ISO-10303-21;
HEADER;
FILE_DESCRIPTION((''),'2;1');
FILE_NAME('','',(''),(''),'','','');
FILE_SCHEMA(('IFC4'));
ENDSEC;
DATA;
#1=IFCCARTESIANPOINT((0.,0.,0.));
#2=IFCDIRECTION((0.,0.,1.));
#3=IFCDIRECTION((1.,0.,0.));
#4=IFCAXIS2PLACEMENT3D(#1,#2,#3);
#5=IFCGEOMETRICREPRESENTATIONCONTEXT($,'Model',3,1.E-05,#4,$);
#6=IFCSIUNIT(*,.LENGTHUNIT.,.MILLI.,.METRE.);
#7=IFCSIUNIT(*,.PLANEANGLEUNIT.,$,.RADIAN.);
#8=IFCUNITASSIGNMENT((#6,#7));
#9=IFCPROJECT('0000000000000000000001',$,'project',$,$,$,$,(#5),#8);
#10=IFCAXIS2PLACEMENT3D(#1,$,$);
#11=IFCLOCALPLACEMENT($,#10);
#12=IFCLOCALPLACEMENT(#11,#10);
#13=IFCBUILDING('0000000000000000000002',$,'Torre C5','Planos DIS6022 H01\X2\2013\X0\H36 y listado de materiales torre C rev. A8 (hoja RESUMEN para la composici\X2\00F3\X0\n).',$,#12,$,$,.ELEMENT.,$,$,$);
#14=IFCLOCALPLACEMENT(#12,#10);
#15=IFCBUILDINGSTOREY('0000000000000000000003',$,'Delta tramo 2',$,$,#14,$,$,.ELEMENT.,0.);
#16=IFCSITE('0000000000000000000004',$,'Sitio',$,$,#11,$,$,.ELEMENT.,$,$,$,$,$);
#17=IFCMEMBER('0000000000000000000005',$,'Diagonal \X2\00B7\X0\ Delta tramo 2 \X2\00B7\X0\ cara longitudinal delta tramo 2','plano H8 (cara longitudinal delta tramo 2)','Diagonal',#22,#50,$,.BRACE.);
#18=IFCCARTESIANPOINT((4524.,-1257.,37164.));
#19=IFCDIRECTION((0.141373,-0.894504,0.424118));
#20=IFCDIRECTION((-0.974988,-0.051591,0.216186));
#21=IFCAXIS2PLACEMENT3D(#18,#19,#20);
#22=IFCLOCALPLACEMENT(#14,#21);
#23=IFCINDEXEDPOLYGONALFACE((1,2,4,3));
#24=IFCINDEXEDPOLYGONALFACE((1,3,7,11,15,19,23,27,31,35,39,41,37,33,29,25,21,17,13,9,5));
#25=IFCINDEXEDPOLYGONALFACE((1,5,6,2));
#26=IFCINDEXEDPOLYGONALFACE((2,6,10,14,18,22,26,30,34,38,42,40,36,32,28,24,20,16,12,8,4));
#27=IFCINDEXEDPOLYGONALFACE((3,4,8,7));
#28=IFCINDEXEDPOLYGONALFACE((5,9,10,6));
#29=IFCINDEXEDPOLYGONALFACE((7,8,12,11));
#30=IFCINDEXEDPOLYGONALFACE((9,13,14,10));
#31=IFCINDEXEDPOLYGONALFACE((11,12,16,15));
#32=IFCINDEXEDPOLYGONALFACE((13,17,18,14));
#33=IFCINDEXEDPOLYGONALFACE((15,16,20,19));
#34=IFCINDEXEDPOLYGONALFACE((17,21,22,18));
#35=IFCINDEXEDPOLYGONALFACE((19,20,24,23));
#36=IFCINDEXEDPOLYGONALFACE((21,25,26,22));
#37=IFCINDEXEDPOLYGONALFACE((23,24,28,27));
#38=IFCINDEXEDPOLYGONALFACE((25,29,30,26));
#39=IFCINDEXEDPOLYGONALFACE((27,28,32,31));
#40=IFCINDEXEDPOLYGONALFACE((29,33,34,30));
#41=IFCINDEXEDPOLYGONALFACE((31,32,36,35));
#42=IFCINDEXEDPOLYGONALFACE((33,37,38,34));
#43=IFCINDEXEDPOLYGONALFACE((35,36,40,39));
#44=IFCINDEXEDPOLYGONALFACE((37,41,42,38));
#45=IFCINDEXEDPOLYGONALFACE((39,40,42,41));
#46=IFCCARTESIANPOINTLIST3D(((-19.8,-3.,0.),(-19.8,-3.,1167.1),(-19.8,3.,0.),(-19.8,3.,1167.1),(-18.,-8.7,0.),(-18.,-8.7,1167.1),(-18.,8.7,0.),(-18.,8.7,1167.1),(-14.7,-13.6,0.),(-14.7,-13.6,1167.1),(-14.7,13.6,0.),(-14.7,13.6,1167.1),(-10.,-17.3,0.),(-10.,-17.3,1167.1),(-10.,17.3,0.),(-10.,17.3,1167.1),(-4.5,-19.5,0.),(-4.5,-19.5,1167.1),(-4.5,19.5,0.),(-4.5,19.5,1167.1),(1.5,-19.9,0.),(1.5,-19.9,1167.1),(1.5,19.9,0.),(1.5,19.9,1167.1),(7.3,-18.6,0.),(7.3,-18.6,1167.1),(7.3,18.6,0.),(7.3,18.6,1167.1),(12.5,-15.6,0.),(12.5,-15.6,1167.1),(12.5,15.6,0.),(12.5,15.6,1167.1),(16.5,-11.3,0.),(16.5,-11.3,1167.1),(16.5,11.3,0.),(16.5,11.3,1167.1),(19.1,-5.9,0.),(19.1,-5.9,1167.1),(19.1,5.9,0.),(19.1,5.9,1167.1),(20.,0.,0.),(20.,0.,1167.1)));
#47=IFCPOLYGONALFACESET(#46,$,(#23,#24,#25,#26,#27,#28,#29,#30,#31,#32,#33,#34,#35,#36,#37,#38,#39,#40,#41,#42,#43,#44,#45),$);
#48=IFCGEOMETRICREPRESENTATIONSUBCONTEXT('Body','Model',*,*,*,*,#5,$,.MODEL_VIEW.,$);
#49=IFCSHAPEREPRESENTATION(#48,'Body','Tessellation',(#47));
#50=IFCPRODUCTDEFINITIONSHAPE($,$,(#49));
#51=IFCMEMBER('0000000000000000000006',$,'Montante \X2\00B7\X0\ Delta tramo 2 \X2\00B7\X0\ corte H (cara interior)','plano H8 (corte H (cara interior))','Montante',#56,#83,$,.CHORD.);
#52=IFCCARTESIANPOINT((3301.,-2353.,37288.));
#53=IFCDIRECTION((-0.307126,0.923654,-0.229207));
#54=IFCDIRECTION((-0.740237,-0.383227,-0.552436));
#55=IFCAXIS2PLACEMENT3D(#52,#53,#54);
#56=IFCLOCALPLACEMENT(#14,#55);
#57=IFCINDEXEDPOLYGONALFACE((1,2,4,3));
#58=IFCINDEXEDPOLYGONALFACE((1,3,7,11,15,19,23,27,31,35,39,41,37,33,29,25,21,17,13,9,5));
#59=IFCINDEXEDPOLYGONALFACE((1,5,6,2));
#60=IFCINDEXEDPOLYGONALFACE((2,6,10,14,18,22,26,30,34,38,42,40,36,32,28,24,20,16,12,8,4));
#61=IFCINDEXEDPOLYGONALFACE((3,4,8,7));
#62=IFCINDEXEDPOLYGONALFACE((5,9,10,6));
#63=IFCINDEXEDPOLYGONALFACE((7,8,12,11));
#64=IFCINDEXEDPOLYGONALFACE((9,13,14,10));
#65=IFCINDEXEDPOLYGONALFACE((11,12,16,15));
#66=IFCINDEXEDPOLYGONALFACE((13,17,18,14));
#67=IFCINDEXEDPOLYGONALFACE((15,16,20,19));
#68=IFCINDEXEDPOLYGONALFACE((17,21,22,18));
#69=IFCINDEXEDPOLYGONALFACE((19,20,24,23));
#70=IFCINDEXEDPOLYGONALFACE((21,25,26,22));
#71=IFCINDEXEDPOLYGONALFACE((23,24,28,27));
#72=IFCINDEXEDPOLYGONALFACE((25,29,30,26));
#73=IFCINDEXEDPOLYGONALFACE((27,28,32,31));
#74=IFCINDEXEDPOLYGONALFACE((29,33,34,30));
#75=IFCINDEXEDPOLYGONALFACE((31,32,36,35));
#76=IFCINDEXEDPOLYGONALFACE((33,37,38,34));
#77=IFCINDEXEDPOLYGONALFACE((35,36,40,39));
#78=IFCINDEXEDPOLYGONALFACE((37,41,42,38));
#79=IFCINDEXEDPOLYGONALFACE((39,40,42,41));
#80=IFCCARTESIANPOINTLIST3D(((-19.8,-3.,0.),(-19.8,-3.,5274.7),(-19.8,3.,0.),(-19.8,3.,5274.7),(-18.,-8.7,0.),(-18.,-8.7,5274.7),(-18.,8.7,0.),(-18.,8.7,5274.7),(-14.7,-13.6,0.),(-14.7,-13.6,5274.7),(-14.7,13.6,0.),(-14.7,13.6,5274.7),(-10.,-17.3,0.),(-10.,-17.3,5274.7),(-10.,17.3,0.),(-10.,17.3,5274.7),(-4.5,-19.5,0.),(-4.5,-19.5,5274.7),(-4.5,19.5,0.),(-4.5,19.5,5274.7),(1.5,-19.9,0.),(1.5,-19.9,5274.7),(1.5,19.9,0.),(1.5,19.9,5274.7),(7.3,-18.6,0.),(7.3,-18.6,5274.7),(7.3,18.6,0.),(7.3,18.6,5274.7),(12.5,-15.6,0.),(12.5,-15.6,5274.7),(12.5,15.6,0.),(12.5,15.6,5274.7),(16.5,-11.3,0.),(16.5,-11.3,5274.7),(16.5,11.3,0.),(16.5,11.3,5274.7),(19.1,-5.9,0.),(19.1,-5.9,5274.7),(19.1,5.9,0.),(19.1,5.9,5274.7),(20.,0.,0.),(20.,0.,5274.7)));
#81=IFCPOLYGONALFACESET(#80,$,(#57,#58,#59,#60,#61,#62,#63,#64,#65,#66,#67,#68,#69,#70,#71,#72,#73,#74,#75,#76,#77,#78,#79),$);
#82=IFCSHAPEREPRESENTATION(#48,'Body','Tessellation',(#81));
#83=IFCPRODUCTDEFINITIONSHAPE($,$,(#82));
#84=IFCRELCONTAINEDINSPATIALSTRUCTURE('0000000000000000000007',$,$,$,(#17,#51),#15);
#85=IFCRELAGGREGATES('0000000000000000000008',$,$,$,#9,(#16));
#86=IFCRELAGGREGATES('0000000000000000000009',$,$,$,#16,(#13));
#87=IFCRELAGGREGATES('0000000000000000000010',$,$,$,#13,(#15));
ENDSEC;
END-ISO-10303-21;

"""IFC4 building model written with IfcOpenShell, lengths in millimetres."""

from ifc_helpers import new_model, si_unit, frame, origin, origin_with_axes, place, context, subcontext, project, spatial, circle, extrude, element, save


model = new_model("IFC4")

# Units and contexts
model_context = context("Model", 3, precision=1e-05, world=origin_with_axes())
body_context = subcontext(model_context, "Body", "Model", "MODEL_VIEW")
ifc_project = project(units=[si_unit("LENGTHUNIT", "METRE", prefix="MILLI"), si_unit("PLANEANGLEUNIT", "RADIAN")], contexts=[model_context])

# Site, building, storey
site_placement = place(None, origin())
site = spatial("IfcSite", under=ifc_project, at=site_placement, Name="Sitio", CompositionType="ELEMENT")
building_placement = place(site_placement, origin())
building = spatial("IfcBuilding", under=site, at=building_placement, Name="Torre C5", Description="Planos DIS6022 H01–H36 y listado de materiales torre C rev. A8 (hoja RESUMEN para la composición).", CompositionType="ELEMENT")
storey_placement = place(building_placement, origin())
storey = spatial("IfcBuildingStorey", under=building, at=storey_placement, Name="Delta tramo 2", CompositionType="ELEMENT", Elevation=0.0)

# Members
member_1_placement = place(storey_placement, frame((4524.0, -1257.0, 37164.0), z_axis=(0.141373, -0.894504, 0.424118), x_axis=(-0.974988, -0.051591, 0.216186)))
element("IfcMember", 1, at=member_1_placement, inside=storey, Name="Diagonal · Delta tramo 2 · cara longitudinal delta tramo 2", Description="plano H8 (cara longitudinal delta tramo 2)", ObjectType="Diagonal", PredefinedType="BRACE", context=body_context, shape_type="SweptSolid", body=[
    extrude(circle(Radius=20.0), None, (0.0, 0.0, 1.0), 1167.1),
])
member_2_placement = place(storey_placement, frame((3301.0, -2353.0, 37288.0), z_axis=(-0.307126, 0.923654, -0.229207), x_axis=(-0.740237, -0.383227, -0.552436)))
element("IfcMember", 2, at=member_2_placement, inside=storey, Name="Montante · Delta tramo 2 · corte H (cara interior)", Description="plano H8 (corte H (cara interior))", ObjectType="Montante", PredefinedType="CHORD", context=body_context, shape_type="SweptSolid", body=[
    extrude(circle(Radius=20.0), None, (0.0, 0.0, 1.0), 5274.7),
])

save(model, "model.ifc")
